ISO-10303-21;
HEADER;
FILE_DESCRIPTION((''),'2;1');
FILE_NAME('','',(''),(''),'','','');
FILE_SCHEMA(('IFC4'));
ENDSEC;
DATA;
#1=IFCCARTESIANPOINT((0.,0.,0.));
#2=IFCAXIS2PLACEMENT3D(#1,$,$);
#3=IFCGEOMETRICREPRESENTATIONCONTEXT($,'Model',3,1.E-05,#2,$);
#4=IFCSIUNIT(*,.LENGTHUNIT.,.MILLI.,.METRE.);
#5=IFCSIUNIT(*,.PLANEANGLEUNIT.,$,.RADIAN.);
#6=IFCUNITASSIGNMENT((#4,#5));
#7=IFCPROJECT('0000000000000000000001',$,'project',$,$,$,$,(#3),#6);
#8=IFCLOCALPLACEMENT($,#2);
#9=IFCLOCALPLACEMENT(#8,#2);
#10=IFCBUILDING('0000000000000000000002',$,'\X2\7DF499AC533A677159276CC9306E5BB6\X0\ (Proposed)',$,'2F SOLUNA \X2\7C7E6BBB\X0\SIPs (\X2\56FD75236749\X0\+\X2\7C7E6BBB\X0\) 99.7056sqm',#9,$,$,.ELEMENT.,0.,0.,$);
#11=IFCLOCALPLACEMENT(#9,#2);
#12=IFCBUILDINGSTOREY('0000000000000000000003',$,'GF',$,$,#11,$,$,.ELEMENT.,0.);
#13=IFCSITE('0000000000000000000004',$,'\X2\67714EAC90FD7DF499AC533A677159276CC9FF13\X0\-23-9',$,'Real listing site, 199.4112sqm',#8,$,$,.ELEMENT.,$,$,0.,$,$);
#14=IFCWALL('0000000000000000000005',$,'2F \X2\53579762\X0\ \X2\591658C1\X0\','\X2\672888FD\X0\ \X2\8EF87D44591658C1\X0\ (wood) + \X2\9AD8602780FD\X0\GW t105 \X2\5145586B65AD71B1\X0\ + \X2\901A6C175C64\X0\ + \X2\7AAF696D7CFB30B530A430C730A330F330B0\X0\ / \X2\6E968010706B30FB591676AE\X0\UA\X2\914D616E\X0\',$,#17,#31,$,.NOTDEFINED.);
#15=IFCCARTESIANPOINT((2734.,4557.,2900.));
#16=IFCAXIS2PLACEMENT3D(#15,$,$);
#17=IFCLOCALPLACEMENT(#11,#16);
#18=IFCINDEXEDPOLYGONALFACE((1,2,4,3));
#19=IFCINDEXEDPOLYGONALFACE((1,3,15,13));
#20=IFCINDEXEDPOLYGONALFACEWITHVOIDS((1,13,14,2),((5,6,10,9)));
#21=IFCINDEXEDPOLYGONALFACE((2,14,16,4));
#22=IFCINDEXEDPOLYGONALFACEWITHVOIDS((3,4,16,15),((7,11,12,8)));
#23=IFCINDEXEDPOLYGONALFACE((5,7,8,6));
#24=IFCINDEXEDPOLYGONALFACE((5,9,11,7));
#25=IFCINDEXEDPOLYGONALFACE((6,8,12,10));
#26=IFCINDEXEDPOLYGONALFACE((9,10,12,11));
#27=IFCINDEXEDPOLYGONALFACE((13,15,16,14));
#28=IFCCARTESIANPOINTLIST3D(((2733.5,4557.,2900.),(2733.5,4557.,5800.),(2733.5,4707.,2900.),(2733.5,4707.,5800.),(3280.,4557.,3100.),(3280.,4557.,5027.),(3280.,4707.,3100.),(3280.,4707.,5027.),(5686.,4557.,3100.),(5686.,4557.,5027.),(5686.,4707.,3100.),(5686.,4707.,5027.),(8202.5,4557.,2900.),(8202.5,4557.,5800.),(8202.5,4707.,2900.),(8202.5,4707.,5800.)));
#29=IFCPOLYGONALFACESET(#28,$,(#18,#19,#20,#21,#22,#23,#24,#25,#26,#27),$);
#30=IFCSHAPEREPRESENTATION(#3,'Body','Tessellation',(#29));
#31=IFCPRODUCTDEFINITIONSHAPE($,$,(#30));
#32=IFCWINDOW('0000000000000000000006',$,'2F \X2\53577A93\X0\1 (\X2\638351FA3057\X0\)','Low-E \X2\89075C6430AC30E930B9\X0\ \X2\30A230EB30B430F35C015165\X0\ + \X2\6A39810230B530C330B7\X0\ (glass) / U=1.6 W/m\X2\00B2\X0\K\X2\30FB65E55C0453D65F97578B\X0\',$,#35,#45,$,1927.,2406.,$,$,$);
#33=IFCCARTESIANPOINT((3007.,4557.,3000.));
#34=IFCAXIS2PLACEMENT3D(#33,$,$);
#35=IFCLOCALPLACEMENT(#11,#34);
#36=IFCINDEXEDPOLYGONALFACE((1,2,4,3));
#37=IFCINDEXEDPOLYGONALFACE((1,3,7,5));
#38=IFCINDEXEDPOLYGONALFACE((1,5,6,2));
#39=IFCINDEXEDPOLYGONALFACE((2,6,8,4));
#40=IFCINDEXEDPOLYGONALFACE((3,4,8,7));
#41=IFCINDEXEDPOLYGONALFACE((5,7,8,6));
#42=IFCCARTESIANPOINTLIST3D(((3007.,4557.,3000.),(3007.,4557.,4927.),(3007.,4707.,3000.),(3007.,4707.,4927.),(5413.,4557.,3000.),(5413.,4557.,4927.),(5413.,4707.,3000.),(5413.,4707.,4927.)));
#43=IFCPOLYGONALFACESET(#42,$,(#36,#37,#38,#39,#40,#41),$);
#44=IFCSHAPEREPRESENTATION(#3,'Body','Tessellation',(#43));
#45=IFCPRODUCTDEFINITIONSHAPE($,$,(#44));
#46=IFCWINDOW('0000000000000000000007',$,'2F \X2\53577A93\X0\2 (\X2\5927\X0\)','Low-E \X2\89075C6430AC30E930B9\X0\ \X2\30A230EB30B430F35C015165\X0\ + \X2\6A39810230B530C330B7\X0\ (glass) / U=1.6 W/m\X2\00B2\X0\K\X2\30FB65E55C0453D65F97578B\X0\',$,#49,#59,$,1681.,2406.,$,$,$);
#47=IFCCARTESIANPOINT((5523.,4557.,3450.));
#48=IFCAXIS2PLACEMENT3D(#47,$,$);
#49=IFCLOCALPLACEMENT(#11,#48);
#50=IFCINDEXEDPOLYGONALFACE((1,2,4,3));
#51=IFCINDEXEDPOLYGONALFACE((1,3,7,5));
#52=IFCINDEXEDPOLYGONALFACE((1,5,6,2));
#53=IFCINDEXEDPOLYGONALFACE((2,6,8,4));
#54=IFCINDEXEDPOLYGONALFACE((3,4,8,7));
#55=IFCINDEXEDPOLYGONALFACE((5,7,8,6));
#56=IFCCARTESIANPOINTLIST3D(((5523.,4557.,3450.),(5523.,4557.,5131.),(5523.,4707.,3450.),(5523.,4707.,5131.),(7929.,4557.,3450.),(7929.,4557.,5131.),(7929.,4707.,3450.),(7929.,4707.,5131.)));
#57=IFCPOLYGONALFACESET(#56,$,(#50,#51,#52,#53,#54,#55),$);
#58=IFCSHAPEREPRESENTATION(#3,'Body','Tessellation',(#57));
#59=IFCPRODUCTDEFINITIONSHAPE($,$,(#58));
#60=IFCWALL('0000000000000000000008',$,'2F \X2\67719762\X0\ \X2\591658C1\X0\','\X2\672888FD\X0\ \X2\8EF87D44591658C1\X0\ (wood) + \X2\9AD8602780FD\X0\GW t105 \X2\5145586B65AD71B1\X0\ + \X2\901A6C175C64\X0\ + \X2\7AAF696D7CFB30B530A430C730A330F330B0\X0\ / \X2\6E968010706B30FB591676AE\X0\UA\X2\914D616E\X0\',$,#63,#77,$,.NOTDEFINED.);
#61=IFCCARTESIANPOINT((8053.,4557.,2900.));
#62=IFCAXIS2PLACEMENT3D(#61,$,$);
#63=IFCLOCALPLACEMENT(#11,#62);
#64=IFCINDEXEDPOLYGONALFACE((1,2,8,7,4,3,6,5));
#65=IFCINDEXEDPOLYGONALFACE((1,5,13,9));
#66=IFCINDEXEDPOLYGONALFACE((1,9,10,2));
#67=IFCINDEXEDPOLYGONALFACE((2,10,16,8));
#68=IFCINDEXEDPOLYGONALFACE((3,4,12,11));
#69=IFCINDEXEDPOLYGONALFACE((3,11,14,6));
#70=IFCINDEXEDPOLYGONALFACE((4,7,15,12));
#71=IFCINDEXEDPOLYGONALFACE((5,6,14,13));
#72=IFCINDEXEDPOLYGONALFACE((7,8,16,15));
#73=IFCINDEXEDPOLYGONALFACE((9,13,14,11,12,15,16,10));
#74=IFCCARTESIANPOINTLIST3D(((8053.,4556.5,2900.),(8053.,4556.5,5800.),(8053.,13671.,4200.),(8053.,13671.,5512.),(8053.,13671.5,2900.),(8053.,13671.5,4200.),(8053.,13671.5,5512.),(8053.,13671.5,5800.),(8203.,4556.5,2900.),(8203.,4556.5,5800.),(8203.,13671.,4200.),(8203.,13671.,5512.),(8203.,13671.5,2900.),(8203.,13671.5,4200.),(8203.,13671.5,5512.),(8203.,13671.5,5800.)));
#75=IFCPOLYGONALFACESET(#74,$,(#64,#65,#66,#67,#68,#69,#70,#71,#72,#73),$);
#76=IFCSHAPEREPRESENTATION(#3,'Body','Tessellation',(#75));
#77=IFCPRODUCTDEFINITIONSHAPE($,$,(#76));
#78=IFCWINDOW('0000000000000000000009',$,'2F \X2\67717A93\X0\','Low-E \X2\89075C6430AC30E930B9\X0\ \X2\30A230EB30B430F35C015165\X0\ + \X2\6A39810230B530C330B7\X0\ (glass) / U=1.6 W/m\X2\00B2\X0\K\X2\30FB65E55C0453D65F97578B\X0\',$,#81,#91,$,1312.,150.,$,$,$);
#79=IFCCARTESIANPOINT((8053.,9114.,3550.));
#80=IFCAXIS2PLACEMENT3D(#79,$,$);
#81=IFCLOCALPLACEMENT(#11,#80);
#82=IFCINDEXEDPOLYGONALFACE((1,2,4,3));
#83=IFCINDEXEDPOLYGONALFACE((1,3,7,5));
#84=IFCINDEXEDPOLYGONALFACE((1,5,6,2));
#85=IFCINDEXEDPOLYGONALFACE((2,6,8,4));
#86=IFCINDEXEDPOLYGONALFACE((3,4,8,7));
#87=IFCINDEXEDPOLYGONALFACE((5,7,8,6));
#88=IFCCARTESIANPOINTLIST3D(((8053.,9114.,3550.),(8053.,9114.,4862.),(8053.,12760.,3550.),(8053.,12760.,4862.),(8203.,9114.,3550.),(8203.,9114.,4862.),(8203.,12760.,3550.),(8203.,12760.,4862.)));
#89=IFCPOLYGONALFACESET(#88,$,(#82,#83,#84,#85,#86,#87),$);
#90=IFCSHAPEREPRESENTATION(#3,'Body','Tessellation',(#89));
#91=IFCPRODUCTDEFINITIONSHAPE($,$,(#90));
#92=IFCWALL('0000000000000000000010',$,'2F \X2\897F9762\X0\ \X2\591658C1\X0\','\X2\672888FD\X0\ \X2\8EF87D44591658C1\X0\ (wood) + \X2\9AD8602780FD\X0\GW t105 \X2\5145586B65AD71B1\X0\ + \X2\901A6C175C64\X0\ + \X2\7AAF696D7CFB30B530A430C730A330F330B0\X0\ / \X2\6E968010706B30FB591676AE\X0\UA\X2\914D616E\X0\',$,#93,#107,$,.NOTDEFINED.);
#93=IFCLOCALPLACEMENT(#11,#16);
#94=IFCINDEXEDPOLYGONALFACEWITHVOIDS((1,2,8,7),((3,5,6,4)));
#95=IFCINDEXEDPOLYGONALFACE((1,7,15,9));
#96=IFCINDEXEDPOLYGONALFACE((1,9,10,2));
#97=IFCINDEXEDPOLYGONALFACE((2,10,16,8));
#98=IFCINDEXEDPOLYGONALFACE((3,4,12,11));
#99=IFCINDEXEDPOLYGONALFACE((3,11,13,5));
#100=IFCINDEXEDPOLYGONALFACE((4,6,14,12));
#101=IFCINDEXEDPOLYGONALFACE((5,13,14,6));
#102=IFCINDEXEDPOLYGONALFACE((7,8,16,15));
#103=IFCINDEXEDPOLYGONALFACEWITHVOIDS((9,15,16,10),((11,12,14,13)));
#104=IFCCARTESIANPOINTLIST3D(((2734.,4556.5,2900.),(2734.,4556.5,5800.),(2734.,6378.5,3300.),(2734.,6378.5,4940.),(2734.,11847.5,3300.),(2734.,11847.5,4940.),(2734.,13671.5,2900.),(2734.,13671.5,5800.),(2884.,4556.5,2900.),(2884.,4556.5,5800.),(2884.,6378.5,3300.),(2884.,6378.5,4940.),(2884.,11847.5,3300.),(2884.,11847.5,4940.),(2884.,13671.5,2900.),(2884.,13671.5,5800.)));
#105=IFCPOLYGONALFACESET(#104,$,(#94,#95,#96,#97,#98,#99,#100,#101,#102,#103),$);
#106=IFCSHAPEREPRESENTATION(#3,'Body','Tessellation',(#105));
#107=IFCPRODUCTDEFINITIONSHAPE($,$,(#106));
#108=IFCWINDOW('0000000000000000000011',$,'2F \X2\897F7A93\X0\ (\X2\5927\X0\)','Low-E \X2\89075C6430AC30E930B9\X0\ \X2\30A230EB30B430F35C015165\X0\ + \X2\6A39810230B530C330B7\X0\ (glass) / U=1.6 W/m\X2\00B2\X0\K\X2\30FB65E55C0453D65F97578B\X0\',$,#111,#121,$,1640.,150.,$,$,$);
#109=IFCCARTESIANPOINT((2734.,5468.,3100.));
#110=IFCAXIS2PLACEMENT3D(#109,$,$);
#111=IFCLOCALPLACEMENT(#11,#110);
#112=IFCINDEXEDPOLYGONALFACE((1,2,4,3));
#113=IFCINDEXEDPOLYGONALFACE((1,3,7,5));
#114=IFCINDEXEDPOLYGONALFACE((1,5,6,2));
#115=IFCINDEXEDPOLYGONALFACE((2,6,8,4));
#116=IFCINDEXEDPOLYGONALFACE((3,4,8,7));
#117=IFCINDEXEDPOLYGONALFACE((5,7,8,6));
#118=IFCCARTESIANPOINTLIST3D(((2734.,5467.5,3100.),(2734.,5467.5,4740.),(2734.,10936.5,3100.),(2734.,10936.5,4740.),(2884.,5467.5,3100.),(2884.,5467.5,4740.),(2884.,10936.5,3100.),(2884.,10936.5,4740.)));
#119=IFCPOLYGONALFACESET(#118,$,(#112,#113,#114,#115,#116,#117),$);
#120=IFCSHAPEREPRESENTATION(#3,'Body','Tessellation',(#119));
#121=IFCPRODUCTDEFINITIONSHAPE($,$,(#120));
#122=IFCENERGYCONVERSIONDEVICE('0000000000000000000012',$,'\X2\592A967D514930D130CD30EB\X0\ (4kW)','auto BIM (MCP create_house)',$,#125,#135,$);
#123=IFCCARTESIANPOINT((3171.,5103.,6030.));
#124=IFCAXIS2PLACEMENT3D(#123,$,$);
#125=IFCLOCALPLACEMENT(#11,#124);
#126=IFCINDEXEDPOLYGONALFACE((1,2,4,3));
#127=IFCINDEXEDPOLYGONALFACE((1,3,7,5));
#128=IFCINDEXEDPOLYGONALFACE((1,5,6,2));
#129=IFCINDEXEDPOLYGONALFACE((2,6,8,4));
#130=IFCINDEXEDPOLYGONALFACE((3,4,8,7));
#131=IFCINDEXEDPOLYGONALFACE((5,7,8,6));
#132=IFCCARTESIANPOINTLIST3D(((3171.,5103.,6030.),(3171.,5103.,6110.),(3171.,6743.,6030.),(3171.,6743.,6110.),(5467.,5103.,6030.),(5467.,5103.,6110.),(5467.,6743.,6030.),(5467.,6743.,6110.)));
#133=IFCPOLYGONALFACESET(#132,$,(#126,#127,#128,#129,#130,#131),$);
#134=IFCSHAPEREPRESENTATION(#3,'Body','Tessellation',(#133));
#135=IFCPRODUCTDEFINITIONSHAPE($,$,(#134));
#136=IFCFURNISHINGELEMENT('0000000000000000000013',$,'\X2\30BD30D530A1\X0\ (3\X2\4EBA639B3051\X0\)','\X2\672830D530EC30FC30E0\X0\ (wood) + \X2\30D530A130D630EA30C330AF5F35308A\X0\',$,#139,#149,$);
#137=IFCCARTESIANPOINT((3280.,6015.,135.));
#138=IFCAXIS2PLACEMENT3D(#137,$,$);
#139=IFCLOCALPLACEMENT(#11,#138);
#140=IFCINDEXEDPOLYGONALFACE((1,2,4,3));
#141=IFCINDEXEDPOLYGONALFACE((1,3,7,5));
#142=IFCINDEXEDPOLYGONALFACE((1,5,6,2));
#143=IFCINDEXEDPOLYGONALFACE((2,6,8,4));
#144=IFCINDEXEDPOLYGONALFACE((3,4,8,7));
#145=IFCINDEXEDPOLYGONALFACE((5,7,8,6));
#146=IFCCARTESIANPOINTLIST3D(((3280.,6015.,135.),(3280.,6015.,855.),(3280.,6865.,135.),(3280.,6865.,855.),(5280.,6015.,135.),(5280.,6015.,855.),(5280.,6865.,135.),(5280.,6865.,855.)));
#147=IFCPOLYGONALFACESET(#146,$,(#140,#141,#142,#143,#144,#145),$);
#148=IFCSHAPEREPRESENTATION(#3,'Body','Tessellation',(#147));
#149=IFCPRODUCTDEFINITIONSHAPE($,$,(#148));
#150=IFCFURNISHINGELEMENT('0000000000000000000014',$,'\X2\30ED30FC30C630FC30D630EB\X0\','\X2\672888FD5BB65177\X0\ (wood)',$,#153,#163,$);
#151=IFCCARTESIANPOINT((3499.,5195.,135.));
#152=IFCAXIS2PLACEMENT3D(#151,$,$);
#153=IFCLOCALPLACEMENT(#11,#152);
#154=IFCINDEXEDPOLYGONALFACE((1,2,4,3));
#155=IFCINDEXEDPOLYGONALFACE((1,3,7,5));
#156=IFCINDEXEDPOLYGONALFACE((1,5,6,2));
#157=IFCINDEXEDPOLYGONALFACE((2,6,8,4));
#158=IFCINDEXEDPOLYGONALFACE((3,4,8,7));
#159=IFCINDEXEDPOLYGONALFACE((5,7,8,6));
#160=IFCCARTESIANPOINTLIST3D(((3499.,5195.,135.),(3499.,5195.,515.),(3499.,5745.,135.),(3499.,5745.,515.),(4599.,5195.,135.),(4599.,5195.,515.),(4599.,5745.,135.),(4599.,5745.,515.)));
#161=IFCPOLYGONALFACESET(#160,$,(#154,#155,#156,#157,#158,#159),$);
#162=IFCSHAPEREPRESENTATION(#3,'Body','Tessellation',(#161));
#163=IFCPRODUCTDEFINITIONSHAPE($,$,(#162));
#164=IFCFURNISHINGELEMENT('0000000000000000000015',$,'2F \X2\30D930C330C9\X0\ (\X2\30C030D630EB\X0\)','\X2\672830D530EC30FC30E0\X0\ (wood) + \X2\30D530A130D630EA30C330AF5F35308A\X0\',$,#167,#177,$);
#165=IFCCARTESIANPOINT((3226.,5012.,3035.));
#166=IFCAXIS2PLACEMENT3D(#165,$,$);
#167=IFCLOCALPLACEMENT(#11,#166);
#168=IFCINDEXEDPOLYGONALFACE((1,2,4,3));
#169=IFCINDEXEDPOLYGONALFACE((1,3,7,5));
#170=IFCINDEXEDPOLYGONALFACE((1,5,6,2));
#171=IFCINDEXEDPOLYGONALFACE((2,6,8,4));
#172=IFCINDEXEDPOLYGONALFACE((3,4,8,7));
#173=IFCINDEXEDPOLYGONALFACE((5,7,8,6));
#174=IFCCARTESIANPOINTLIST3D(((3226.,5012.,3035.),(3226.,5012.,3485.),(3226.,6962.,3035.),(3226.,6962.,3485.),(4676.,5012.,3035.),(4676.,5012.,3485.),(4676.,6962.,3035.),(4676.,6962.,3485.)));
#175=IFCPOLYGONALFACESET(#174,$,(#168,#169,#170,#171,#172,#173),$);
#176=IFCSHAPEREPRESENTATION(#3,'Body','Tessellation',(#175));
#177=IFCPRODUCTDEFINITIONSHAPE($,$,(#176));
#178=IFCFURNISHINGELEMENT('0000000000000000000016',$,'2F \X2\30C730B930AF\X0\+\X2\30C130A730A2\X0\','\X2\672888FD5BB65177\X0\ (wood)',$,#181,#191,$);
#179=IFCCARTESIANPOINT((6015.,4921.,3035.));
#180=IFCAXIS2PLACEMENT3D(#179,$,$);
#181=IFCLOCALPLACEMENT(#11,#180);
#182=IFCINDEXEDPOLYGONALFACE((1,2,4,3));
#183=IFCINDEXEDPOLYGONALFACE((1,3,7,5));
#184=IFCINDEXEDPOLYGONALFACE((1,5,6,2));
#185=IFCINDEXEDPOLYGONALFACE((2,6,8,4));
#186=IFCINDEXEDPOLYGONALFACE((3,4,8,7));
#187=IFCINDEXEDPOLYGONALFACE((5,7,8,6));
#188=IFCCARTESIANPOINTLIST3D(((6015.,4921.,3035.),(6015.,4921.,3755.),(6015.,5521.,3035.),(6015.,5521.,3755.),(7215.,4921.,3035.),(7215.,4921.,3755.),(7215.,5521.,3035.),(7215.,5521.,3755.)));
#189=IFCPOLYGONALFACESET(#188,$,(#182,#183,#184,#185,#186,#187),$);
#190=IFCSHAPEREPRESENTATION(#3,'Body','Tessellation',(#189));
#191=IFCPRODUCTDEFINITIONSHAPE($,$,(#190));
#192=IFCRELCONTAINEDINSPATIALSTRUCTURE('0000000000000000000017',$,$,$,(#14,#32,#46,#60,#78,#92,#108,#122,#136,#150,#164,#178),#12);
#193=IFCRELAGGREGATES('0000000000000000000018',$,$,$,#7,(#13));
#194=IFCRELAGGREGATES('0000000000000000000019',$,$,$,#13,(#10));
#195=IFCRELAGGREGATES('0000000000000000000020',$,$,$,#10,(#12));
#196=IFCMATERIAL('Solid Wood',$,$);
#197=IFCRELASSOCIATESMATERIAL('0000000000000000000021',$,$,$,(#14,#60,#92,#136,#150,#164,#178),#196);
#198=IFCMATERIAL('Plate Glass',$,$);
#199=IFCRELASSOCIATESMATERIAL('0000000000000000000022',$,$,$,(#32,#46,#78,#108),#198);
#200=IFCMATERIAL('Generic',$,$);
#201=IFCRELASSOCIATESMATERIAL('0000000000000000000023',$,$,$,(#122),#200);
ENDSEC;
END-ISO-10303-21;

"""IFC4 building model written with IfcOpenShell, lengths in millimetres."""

from ifc_helpers import new_model, si_unit, frame, frame_2d, origin, place, context, project, spatial, rectangle, extrude, material, element, fill, save


model = new_model("IFC4")

# Units and contexts
model_context = context("Model", 3, precision=1e-05, world=origin())
ifc_project = project(units=[si_unit("LENGTHUNIT", "METRE", prefix="MILLI"), si_unit("PLANEANGLEUNIT", "RADIAN")], contexts=[model_context])

# Site, building, storey
site_placement = place(None, origin())
site = spatial("IfcSite", under=ifc_project, at=site_placement, Name="東京都練馬区東大泉３-23-9", ObjectType="Real listing site, 199.4112sqm", CompositionType="ELEMENT", RefElevation=0.0)
building_placement = place(site_placement, origin())
building = spatial("IfcBuilding", under=site, at=building_placement, Name="練馬区東大泉の家 (Proposed)", ObjectType="2F SOLUNA 籾殻SIPs (国産杉+籾殻) 99.7056sqm", CompositionType="ELEMENT", ElevationOfRefHeight=0.0, ElevationOfTerrain=0.0)
storey_placement = place(building_placement, origin())
storey = spatial("IfcBuildingStorey", under=building, at=storey_placement, Name="GF", CompositionType="ELEMENT", Elevation=0.0)

# Shared definitions
ifc_material_1 = material(Name="Solid Wood")

# Wall, openings, windows
wall_1_placement = place(storey_placement, frame((2734.0, 4557.0, 2900.0)))
wall_1 = element("IfcWall", 1, at=wall_1_placement, inside=storey, material=ifc_material_1, Name="2F 南面 外壁", Description="木製 軸組外壁 (wood) + 高性能GW t105 充填断熱 + 通気層 + 窯業系サイディング / 準耐火・外皮UA配慮", PredefinedType="NOTDEFINED", context=model_context, shape_type="SweptSolid", body=[
    extrude(rectangle(XDim=5469.0, YDim=150.0, at=frame_2d((2734.0, 75.0))), frame((2734.0, 4557.0, 2900.0)), (0.0, 0.0, 1.0), 2900.0),
])
opening_1_placement = place(storey_placement, frame((3007.0, 4557.0, 3000.0)))
opening_1 = element("IfcOpeningElement", 2, at=opening_1_placement, cuts=wall_1, PredefinedType="NOTDEFINED", context=model_context, shape_type="SweptSolid", body=[
    extrude(rectangle(XDim=2406.0, YDim=150.0, at=frame_2d((1203.0, 75.0))), frame((3007.0, 4557.0, 3000.0)), (0.0, 0.0, 1.0), 1927.0),
])
opening_2_placement = place(storey_placement, frame((5523.0, 4557.0, 3450.0)))
opening_2 = element("IfcOpeningElement", 3, at=opening_2_placement, cuts=wall_1, PredefinedType="NOTDEFINED", context=model_context, shape_type="SweptSolid", body=[
    extrude(rectangle(XDim=2406.0, YDim=150.0, at=frame_2d((1203.0, 75.0))), frame((5523.0, 4557.0, 3450.0)), (0.0, 0.0, 1.0), 1681.0),
])
ifc_material_2 = material(Name="Plate Glass")
window_1_placement = place(storey_placement, frame((3007.0, 4557.0, 3000.0)))
window_1 = element("IfcWindow", 4, at=window_1_placement, inside=storey, material=ifc_material_2, Name="2F 南窓1 (掃出し)", Description="Low-E 複層ガラス アルゴン封入 + 樹脂サッシ (glass) / U=1.6 W/m²K・日射取得型", OverallHeight=1927.0, OverallWidth=2406.0, context=model_context, shape_type="SweptSolid", body=[
    extrude(rectangle(XDim=2406.0, YDim=150.0, at=frame_2d((1203.0, 75.0))), frame((3007.0, 4557.0, 3000.0)), (0.0, 0.0, 1.0), 1927.0),
])
fill(opening_1, window_1)
window_2_placement = place(storey_placement, frame((5523.0, 4557.0, 3450.0)))
window_2 = element("IfcWindow", 5, at=window_2_placement, inside=storey, material=ifc_material_2, Name="2F 南窓2 (大)", Description="Low-E 複層ガラス アルゴン封入 + 樹脂サッシ (glass) / U=1.6 W/m²K・日射取得型", OverallHeight=1681.0, OverallWidth=2406.0, context=model_context, shape_type="SweptSolid", body=[
    extrude(rectangle(XDim=2406.0, YDim=150.0, at=frame_2d((1203.0, 75.0))), frame((5523.0, 4557.0, 3450.0)), (0.0, 0.0, 1.0), 1681.0),
])
fill(opening_2, window_2)

# Walls, openings, windows
wall_2_placement = place(storey_placement, frame((8053.0, 4557.0, 2900.0)))
wall_2 = element("IfcWall", 6, at=wall_2_placement, inside=storey, material=ifc_material_1, Name="2F 東面 外壁", Description="木製 軸組外壁 (wood) + 高性能GW t105 充填断熱 + 通気層 + 窯業系サイディング / 準耐火・外皮UA配慮", PredefinedType="NOTDEFINED", context=model_context, shape_type="SweptSolid", body=[
    extrude(rectangle(XDim=150.0, YDim=9115.0, at=frame_2d((75.0, 4557.0))), frame((8053.0, 4557.0, 2900.0)), (0.0, 0.0, 1.0), 2900.0),
])
opening_3_placement = place(storey_placement, frame((8053.0, 9114.0, 3550.0)))
opening_3 = element("IfcOpeningElement", 7, at=opening_3_placement, cuts=wall_2, PredefinedType="NOTDEFINED", context=model_context, shape_type="SweptSolid", body=[
    extrude(rectangle(XDim=150.0, YDim=3646.0, at=frame_2d((75.0, 1823.0))), frame((8053.0, 9114.0, 3550.0)), (0.0, 0.0, 1.0), 1312.0),
])
window_3_placement = place(storey_placement, frame((8053.0, 9114.0, 3550.0)))
window_3 = element("IfcWindow", 8, at=window_3_placement, inside=storey, material=ifc_material_2, Name="2F 東窓", Description="Low-E 複層ガラス アルゴン封入 + 樹脂サッシ (glass) / U=1.6 W/m²K・日射取得型", OverallHeight=1312.0, OverallWidth=150.0, context=model_context, shape_type="SweptSolid", body=[
    extrude(rectangle(XDim=150.0, YDim=3646.0, at=frame_2d((75.0, 1823.0))), frame((8053.0, 9114.0, 3550.0)), (0.0, 0.0, 1.0), 1312.0),
])
fill(opening_3, window_3)
wall_3_placement = place(storey_placement, frame((2734.0, 4557.0, 2900.0)))
wall_3 = element("IfcWall", 9, at=wall_3_placement, inside=storey, material=ifc_material_1, Name="2F 西面 外壁", Description="木製 軸組外壁 (wood) + 高性能GW t105 充填断熱 + 通気層 + 窯業系サイディング / 準耐火・外皮UA配慮", PredefinedType="NOTDEFINED", context=model_context, shape_type="SweptSolid", body=[
    extrude(rectangle(XDim=150.0, YDim=9115.0, at=frame_2d((75.0, 4557.0))), frame((2734.0, 4557.0, 2900.0)), (0.0, 0.0, 1.0), 2900.0),
])
opening_4_placement = place(storey_placement, frame((2734.0, 5468.0, 3100.0)))
opening_4 = element("IfcOpeningElement", 10, at=opening_4_placement, cuts=wall_3, PredefinedType="NOTDEFINED", context=model_context, shape_type="SweptSolid", body=[
    extrude(rectangle(XDim=150.0, YDim=5469.0, at=frame_2d((75.0, 2734.0))), frame((2734.0, 5468.0, 3100.0)), (0.0, 0.0, 1.0), 1640.0),
])
window_4_placement = place(storey_placement, frame((2734.0, 5468.0, 3100.0)))
window_4 = element("IfcWindow", 11, at=window_4_placement, inside=storey, material=ifc_material_2, Name="2F 西窓 (大)", Description="Low-E 複層ガラス アルゴン封入 + 樹脂サッシ (glass) / U=1.6 W/m²K・日射取得型", OverallHeight=1640.0, OverallWidth=150.0, context=model_context, shape_type="SweptSolid", body=[
    extrude(rectangle(XDim=150.0, YDim=5469.0, at=frame_2d((75.0, 2734.0))), frame((2734.0, 5468.0, 3100.0)), (0.0, 0.0, 1.0), 1640.0),
])
fill(opening_4, window_4)

# Shared definitions
ifc_material_3 = material(Name="Generic")

# Energy conversion device
energy_conversion_device_placement = place(storey_placement, frame((3171.0, 5103.0, 6030.0)))
element("IfcEnergyConversionDevice", 12, at=energy_conversion_device_placement, inside=storey, material=ifc_material_3, Name="太陽光パネル (4kW)", Description="auto BIM (MCP create_house)", context=model_context, shape_type="SweptSolid", body=[
    extrude(rectangle(XDim=2296.0, YDim=1640.0, at=frame_2d((1148.0, 820.0))), frame((3171.0, 5103.0, 6030.0)), (0.0, 0.0, 1.0), 80.0),
])

# Furnishing elements
furnishing_1_placement = place(storey_placement, frame((3280.0, 6015.0, 135.0)))
element("IfcFurnishingElement", 13, at=furnishing_1_placement, inside=storey, material=ifc_material_1, Name="ソファ (3人掛け)", Description="木フレーム (wood) + ファブリック張り", context=model_context, shape_type="SweptSolid", body=[
    extrude(rectangle(XDim=2000.0, YDim=850.0, at=frame_2d((1000.0, 425.0))), frame((3280.0, 6015.0, 135.0)), (0.0, 0.0, 1.0), 720.0),
])
furnishing_2_placement = place(storey_placement, frame((3499.0, 5195.0, 135.0)))
element("IfcFurnishingElement", 14, at=furnishing_2_placement, inside=storey, material=ifc_material_1, Name="ローテーブル", Description="木製家具 (wood)", context=model_context, shape_type="SweptSolid", body=[
    extrude(rectangle(XDim=1100.0, YDim=550.0, at=frame_2d((550.0, 275.0))), frame((3499.0, 5195.0, 135.0)), (0.0, 0.0, 1.0), 380.0),
])
furnishing_3_placement = place(storey_placement, frame((3226.0, 5012.0, 3035.0)))
element("IfcFurnishingElement", 15, at=furnishing_3_placement, inside=storey, material=ifc_material_1, Name="2F ベッド (ダブル)", Description="木フレーム (wood) + ファブリック張り", context=model_context, shape_type="SweptSolid", body=[
    extrude(rectangle(XDim=1450.0, YDim=1950.0, at=frame_2d((725.0, 975.0))), frame((3226.0, 5012.0, 3035.0)), (0.0, 0.0, 1.0), 450.0),
])
furnishing_4_placement = place(storey_placement, frame((6015.0, 4921.0, 3035.0)))
element("IfcFurnishingElement", 16, at=furnishing_4_placement, inside=storey, material=ifc_material_1, Name="2F デスク+チェア", Description="木製家具 (wood)", context=model_context, shape_type="SweptSolid", body=[
    extrude(rectangle(XDim=1200.0, YDim=600.0, at=frame_2d((600.0, 300.0))), frame((6015.0, 4921.0, 3035.0)), (0.0, 0.0, 1.0), 720.0),
])

save(model, "model.ifc")
